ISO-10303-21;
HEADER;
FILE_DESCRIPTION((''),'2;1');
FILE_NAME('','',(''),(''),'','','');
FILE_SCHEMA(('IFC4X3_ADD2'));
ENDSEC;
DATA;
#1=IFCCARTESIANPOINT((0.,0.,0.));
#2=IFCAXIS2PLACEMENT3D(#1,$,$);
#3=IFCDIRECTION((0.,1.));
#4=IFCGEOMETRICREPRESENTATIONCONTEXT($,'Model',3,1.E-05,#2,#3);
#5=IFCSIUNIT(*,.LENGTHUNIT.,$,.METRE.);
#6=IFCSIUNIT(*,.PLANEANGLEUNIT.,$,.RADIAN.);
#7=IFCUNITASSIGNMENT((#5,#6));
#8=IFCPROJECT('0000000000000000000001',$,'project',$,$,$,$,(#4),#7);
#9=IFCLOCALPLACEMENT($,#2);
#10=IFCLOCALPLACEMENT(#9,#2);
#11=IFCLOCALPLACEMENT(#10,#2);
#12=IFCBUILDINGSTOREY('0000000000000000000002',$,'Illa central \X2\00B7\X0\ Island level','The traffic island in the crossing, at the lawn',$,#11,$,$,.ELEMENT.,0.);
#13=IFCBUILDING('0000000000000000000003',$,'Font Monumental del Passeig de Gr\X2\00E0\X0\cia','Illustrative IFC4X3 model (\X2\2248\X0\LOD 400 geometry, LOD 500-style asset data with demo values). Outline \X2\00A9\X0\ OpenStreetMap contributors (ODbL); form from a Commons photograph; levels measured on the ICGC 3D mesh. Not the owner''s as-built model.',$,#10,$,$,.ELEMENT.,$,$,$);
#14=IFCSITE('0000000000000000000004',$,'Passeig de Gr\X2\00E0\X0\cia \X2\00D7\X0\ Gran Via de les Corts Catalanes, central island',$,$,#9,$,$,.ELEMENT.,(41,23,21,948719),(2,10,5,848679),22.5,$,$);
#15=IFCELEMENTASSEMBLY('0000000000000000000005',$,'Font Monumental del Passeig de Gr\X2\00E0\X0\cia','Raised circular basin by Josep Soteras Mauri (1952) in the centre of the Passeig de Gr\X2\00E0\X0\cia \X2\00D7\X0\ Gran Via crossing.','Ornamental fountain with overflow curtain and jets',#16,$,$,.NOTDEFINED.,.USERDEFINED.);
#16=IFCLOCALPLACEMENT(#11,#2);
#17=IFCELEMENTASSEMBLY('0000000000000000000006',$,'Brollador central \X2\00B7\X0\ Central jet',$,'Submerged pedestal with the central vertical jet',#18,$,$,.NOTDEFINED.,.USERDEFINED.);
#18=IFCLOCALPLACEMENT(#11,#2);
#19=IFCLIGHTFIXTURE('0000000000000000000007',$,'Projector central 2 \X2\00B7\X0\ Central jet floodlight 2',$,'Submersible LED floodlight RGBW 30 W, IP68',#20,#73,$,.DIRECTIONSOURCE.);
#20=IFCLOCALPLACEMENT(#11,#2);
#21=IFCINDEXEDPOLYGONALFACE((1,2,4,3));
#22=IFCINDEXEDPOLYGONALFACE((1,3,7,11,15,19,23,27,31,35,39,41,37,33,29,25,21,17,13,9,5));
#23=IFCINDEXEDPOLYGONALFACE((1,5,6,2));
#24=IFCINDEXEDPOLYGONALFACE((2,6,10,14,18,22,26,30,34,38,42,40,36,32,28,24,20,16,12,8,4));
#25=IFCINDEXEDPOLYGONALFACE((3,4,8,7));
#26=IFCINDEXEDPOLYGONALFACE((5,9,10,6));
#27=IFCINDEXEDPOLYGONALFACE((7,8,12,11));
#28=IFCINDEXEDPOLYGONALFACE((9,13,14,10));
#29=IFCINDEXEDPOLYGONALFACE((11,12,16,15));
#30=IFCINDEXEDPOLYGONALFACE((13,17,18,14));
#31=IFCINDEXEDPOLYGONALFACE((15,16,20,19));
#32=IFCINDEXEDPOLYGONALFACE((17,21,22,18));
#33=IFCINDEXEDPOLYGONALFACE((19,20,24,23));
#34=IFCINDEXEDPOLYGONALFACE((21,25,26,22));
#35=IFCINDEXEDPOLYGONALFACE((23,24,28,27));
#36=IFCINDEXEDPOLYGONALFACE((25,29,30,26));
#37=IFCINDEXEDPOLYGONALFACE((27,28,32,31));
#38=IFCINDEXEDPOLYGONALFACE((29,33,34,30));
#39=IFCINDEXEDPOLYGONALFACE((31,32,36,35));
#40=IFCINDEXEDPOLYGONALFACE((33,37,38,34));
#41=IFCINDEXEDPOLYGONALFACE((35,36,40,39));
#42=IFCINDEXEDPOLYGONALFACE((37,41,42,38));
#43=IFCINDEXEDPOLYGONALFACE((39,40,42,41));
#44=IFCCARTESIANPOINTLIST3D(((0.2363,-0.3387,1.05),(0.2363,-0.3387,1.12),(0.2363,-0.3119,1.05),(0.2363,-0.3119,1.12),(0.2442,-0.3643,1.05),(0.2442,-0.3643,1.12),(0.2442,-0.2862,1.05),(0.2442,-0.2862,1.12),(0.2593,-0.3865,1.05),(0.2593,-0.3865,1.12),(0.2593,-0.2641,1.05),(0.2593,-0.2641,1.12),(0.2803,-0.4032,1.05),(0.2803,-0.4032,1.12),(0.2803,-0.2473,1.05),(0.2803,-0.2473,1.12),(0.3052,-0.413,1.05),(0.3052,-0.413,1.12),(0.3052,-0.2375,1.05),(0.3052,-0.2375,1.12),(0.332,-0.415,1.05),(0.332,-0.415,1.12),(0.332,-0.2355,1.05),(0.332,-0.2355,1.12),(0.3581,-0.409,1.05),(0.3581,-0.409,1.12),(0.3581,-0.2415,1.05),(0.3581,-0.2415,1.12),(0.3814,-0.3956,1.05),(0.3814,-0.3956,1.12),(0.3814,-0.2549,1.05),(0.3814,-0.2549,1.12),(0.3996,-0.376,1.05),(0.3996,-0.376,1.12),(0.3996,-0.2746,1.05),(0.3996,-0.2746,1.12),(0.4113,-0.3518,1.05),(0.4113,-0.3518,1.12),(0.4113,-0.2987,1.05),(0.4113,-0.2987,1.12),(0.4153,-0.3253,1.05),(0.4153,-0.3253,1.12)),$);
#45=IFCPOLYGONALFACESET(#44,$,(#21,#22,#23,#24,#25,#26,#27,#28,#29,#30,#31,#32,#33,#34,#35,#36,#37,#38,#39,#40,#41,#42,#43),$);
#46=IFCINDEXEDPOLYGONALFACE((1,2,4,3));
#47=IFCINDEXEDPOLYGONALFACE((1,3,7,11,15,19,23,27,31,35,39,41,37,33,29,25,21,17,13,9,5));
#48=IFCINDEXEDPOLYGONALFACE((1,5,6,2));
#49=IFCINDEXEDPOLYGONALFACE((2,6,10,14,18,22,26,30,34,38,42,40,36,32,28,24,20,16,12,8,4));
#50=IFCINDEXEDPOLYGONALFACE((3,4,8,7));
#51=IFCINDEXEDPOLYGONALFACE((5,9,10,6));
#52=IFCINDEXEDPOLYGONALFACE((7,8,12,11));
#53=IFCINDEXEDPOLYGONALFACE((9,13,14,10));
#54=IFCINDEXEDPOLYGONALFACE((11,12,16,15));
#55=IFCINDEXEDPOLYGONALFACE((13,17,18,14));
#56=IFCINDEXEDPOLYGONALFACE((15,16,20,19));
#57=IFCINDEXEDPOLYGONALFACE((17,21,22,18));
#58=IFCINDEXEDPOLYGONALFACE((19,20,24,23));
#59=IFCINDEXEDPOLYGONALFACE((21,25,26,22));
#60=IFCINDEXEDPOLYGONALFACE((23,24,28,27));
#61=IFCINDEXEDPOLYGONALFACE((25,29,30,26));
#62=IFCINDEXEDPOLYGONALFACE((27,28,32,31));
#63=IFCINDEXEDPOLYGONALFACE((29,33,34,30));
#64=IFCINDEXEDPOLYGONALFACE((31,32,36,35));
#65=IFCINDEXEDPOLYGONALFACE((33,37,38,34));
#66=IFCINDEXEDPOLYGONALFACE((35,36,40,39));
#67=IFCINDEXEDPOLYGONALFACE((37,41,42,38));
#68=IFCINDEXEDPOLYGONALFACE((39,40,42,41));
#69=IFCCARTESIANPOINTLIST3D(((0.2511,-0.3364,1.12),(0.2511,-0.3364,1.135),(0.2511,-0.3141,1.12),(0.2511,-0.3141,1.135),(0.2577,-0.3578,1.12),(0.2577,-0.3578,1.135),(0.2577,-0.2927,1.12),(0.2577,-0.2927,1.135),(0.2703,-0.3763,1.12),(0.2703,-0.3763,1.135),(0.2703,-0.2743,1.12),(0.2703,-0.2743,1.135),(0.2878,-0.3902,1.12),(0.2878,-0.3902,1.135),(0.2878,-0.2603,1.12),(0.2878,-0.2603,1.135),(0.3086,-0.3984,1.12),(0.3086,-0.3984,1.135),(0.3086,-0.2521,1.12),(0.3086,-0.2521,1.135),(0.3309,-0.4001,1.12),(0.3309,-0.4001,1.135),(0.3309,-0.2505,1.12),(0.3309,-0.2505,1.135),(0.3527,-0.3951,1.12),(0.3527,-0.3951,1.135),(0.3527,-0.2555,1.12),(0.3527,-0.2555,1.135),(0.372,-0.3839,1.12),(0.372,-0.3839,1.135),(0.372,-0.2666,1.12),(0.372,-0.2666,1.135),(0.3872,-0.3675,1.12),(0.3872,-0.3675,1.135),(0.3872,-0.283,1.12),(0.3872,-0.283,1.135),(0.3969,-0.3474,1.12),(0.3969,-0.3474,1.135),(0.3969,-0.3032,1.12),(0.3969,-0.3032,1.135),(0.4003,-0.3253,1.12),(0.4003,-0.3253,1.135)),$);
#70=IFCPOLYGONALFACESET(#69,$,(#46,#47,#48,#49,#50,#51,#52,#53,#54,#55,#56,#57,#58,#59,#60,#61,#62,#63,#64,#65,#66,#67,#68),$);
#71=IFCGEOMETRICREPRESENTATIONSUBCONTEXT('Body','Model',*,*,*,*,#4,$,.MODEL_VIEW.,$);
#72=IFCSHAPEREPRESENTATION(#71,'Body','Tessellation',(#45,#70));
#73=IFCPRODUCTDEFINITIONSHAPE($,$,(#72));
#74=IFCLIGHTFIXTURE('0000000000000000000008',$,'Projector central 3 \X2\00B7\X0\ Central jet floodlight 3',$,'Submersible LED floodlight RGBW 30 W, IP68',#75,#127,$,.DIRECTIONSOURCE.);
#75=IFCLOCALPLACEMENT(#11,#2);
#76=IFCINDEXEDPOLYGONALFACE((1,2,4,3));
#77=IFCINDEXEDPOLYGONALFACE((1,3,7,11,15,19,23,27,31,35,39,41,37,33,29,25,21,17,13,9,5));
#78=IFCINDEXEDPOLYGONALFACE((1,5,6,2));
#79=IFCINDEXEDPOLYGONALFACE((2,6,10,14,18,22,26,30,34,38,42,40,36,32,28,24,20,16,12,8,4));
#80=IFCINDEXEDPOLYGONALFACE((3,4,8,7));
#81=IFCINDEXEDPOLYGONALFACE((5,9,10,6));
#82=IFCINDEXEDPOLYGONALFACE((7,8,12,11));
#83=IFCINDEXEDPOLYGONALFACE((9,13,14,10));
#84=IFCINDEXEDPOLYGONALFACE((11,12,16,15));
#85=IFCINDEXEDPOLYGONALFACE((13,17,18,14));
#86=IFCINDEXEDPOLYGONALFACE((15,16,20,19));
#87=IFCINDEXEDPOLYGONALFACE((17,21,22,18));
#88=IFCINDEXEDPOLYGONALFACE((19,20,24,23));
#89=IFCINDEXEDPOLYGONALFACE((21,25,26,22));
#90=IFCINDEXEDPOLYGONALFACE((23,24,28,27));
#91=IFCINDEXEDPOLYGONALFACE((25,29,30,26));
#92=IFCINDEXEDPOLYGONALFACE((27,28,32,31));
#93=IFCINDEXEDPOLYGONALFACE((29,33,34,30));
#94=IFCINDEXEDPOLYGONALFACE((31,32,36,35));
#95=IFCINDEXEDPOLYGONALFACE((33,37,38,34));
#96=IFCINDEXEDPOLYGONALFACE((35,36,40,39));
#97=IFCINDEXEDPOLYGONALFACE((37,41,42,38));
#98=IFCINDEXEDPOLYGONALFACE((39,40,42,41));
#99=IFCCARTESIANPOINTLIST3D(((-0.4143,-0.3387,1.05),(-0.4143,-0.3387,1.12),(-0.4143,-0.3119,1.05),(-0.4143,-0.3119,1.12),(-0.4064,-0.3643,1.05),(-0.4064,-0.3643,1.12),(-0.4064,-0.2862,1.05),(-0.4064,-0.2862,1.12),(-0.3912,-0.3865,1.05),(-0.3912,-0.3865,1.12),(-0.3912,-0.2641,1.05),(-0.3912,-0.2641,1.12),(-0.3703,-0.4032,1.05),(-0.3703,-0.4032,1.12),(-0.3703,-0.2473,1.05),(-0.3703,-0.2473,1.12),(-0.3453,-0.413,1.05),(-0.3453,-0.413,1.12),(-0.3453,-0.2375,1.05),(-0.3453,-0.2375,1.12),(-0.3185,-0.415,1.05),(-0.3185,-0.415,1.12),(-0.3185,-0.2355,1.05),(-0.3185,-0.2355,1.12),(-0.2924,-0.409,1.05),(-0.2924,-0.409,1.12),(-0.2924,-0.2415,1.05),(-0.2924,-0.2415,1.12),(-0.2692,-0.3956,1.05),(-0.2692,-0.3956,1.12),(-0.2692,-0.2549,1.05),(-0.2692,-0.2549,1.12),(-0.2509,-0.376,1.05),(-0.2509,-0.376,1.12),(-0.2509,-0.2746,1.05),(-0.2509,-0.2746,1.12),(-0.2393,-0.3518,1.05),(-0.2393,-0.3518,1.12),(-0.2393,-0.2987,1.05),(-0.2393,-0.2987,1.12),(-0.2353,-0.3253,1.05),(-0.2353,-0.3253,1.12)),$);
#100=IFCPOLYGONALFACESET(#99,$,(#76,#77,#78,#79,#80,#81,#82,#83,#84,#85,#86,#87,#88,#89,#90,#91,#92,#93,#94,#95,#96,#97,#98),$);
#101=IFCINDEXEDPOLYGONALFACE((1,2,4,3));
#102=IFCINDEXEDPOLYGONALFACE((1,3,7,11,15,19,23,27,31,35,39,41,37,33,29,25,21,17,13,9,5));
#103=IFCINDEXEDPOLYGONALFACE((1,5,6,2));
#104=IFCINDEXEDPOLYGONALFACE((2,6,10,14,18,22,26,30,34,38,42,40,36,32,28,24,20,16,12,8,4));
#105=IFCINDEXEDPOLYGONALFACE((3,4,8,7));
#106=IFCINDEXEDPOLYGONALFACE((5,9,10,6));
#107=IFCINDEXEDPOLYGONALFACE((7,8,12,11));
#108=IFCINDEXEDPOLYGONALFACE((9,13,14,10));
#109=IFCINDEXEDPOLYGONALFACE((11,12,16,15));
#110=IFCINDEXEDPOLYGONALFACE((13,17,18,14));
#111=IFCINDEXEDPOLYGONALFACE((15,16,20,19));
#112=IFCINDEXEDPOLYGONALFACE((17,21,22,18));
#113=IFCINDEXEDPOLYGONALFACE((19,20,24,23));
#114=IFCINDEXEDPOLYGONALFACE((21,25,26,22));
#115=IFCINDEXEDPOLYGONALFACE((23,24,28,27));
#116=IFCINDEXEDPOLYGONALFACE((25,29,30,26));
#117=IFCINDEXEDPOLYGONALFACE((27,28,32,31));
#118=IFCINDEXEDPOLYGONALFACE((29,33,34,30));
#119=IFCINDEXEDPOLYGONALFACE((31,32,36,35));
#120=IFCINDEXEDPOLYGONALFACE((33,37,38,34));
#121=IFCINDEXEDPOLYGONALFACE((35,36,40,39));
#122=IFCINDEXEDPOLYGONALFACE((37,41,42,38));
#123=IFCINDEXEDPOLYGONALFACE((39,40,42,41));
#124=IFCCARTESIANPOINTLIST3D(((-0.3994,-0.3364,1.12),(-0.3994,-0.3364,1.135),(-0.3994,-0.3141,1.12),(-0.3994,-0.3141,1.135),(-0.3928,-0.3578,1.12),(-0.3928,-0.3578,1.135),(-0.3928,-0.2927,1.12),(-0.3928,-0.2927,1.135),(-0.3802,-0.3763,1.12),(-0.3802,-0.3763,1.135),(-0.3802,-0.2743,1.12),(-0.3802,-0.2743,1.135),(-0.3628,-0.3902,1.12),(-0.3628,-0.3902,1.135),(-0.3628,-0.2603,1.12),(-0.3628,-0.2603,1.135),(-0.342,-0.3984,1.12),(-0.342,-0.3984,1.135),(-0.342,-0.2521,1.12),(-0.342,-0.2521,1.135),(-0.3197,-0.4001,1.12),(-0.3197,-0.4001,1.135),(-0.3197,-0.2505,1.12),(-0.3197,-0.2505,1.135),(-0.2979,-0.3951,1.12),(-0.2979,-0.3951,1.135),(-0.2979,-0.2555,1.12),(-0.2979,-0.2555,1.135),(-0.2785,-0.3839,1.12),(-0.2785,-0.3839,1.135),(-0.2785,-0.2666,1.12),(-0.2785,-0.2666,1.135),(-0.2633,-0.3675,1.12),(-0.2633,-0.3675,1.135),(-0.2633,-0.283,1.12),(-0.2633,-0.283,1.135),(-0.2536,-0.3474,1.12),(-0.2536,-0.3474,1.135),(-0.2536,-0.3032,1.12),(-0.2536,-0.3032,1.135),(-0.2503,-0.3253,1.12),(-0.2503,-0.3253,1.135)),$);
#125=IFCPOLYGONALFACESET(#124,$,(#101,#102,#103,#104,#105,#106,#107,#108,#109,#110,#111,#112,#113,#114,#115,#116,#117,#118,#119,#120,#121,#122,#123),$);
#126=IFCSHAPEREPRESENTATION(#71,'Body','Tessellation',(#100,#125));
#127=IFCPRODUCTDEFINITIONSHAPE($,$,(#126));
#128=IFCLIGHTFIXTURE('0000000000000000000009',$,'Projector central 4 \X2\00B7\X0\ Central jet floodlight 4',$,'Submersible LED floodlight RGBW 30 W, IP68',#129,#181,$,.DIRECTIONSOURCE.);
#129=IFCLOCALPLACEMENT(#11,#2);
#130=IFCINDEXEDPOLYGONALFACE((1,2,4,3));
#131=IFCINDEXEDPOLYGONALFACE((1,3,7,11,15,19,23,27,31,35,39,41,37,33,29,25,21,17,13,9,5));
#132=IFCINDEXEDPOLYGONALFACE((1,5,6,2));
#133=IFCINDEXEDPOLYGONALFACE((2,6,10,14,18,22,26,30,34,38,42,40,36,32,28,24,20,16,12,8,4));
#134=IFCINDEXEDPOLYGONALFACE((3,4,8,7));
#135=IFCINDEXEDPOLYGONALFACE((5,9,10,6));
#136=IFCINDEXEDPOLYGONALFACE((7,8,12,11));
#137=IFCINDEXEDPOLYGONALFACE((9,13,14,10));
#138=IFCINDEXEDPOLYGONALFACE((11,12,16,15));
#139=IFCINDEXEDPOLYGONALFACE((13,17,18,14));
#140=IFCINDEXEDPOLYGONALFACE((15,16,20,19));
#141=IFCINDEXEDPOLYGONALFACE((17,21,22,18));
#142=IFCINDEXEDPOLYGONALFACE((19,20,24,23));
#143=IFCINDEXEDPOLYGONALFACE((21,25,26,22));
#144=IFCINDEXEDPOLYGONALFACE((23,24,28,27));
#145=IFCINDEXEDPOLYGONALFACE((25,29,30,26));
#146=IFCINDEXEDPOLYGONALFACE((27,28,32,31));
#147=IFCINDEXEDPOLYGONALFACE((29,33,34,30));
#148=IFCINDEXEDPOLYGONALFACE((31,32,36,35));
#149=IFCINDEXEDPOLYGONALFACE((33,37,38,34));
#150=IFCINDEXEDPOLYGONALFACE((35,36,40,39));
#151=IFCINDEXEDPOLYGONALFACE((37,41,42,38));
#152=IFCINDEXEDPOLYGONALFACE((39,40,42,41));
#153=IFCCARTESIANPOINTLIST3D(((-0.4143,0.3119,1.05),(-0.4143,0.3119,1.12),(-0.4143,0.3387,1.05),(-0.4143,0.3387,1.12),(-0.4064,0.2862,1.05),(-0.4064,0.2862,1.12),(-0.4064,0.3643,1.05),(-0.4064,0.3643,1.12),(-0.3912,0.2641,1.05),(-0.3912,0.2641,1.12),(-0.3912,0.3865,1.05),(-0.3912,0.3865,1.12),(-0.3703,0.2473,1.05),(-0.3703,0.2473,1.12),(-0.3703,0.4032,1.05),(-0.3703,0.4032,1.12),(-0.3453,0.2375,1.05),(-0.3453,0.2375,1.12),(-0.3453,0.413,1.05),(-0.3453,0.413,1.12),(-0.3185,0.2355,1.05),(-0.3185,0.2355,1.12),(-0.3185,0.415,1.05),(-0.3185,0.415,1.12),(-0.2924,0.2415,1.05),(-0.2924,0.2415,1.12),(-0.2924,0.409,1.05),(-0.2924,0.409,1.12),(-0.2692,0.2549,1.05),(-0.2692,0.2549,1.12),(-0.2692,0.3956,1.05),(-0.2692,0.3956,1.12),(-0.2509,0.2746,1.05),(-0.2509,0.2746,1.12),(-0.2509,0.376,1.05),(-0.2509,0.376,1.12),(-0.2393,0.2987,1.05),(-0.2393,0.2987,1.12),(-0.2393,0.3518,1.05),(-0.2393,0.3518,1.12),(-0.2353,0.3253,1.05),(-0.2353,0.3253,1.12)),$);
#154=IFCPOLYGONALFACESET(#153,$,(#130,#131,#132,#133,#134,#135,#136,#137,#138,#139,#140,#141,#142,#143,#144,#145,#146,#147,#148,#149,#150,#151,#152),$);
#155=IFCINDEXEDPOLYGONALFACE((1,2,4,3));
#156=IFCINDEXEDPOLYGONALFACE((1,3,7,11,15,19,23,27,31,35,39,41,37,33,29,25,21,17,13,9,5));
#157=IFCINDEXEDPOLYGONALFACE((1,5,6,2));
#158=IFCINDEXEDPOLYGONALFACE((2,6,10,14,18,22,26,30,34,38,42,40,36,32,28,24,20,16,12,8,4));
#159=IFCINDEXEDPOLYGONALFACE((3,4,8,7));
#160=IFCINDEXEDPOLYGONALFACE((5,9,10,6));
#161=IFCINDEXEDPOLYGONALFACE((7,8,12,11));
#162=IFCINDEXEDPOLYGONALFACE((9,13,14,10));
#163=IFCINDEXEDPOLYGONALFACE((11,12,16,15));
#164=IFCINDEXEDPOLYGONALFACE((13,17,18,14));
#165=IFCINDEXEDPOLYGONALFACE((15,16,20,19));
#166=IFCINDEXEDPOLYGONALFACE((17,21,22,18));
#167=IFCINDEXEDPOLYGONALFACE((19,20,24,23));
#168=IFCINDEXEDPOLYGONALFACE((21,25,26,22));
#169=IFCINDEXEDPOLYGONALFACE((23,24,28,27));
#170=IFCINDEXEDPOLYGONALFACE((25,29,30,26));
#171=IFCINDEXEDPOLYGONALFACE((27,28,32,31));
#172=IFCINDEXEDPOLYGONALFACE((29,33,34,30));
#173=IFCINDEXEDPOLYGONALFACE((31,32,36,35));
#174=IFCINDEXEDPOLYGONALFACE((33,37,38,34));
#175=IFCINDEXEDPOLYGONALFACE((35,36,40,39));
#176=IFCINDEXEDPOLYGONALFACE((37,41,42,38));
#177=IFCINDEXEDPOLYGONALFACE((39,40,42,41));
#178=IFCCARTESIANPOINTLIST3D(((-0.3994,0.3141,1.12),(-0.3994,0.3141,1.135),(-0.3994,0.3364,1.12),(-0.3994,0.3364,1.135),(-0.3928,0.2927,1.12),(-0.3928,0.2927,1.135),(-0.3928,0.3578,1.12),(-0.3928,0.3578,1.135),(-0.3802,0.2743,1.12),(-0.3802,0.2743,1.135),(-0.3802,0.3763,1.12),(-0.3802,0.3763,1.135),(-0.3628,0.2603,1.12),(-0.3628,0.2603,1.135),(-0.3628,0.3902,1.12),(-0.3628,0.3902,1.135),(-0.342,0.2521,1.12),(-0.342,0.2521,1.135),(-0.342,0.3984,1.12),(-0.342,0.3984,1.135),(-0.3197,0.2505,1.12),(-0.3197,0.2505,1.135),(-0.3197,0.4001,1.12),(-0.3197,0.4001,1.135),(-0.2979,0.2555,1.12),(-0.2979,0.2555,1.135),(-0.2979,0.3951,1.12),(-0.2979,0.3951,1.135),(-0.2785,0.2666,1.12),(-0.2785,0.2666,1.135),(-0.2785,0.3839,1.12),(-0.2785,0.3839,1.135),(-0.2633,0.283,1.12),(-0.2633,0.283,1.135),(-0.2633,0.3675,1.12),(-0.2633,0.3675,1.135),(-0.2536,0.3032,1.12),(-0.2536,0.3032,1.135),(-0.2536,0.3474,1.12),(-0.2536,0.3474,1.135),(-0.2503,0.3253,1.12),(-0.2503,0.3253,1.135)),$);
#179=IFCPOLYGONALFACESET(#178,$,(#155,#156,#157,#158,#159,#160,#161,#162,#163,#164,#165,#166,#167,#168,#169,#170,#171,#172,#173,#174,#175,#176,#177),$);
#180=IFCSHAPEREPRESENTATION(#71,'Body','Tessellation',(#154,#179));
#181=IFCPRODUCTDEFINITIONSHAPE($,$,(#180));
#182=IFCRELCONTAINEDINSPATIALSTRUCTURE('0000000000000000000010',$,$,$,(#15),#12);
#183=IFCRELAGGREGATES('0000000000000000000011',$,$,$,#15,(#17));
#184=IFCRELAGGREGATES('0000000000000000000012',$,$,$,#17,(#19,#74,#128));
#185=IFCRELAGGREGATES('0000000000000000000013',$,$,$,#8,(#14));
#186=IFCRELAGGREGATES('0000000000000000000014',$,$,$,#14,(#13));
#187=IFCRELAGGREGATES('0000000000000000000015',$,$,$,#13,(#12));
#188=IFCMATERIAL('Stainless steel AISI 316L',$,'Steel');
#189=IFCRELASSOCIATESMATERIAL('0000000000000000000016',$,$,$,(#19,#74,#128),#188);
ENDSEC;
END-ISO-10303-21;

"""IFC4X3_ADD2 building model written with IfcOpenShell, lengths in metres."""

from ifc_helpers import new_model, si_unit, direction, frame, origin, origin_2d_with_axis, place, context, subcontext, project, spatial, circle, extrude, material, element, aggregate, save


model = new_model("IFC4X3_ADD2")

# Units and contexts
model_context = context("Model", 3, precision=1e-05, world=origin(), true_north=direction((0.0, 1.0)))
body_context = subcontext(model_context, "Body", "Model", "MODEL_VIEW")
ifc_project = project(units=[si_unit("LENGTHUNIT", "METRE"), si_unit("PLANEANGLEUNIT", "RADIAN")], contexts=[model_context])

# Site, building, storey
site_placement = place(None, origin())
site = spatial("IfcSite", under=ifc_project, at=site_placement, Name="Passeig de Gràcia × Gran Via de les Corts Catalanes, central island", CompositionType="ELEMENT", RefLatitude=(41, 23, 21, 948719), RefLongitude=(2, 10, 5, 848679), RefElevation=22.5)
building_placement = place(site_placement, origin())
building = spatial("IfcBuilding", under=site, at=building_placement, Name="Font Monumental del Passeig de Gràcia", Description="Illustrative IFC4X3 model (≈LOD 400 geometry, LOD 500-style asset data with demo values). Outline © OpenStreetMap contributors (ODbL); form from a Commons photograph; levels measured on the ICGC 3D mesh. Not the owner's as-built model.", CompositionType="ELEMENT")
storey_placement = place(building_placement, origin())
storey = spatial("IfcBuildingStorey", under=building, at=storey_placement, Name="Illa central · Island level", Description="The traffic island in the crossing, at the lawn", CompositionType="ELEMENT", Elevation=0.0)

# Element assemblies, light fixtures
assembly_1_placement = place(building_placement, origin())
assembly_1 = element("IfcElementAssembly", 1, at=assembly_1_placement, inside=storey, Name="Font Monumental del Passeig de Gràcia", Description="Raised circular basin by Josep Soteras Mauri (1952) in the centre of the Passeig de Gràcia × Gran Via crossing.", ObjectType="Ornamental fountain with overflow curtain and jets", AssemblyPlace="NOTDEFINED", PredefinedType="USERDEFINED")
assembly_2_placement = place(building_placement, origin())
assembly_2 = element("IfcElementAssembly", 2, at=assembly_2_placement, Name="Brollador central · Central jet", ObjectType="Submerged pedestal with the central vertical jet", AssemblyPlace="NOTDEFINED", PredefinedType="USERDEFINED")
ifc_material_1 = material(Name="Stainless steel AISI 316L", Category="Steel")
light_fixture_1_placement = place(building_placement, origin())
light_fixture_1 = element("IfcLightFixture", 3, at=light_fixture_1_placement, material=ifc_material_1, Name="Projector central 2 · Central jet floodlight 2", ObjectType="Submersible LED floodlight RGBW 30 W, IP68", PredefinedType="DIRECTIONSOURCE", context=body_context, shape_type="SweptSolid", body=[
    extrude(circle(Radius=0.09, at=origin_2d_with_axis()), frame((0.3253, -0.3253, 1.05)), (0.0, 0.0, 1.0), 0.07),
    extrude(circle(Radius=0.075, at=origin_2d_with_axis()), frame((0.3253, -0.3253, 1.12)), (0.0, 0.0, 1.0), 0.015),
])
light_fixture_2_placement = place(building_placement, origin())
light_fixture_2 = element("IfcLightFixture", 4, at=light_fixture_2_placement, material=ifc_material_1, Name="Projector central 3 · Central jet floodlight 3", ObjectType="Submersible LED floodlight RGBW 30 W, IP68", PredefinedType="DIRECTIONSOURCE", context=body_context, shape_type="SweptSolid", body=[
    extrude(circle(Radius=0.09, at=origin_2d_with_axis()), frame((-0.3253, -0.3253, 1.05)), (0.0, 0.0, 1.0), 0.07),
    extrude(circle(Radius=0.075, at=origin_2d_with_axis()), frame((-0.3253, -0.3253, 1.12)), (0.0, 0.0, 1.0), 0.015),
])
light_fixture_3_placement = place(building_placement, origin())
light_fixture_3 = element("IfcLightFixture", 5, at=light_fixture_3_placement, material=ifc_material_1, Name="Projector central 4 · Central jet floodlight 4", ObjectType="Submersible LED floodlight RGBW 30 W, IP68", PredefinedType="DIRECTIONSOURCE", context=body_context, shape_type="SweptSolid", body=[
    extrude(circle(Radius=0.09, at=origin_2d_with_axis()), frame((-0.3253, 0.3253, 1.05)), (0.0, 0.0, 1.0), 0.07),
    extrude(circle(Radius=0.075, at=origin_2d_with_axis()), frame((-0.3253, 0.3253, 1.12)), (0.0, 0.0, 1.0), 0.015),
])
aggregate(assembly_1, [assembly_2])
aggregate(assembly_2, [light_fixture_1, light_fixture_2, light_fixture_3])

save(model, "model.ifc")
